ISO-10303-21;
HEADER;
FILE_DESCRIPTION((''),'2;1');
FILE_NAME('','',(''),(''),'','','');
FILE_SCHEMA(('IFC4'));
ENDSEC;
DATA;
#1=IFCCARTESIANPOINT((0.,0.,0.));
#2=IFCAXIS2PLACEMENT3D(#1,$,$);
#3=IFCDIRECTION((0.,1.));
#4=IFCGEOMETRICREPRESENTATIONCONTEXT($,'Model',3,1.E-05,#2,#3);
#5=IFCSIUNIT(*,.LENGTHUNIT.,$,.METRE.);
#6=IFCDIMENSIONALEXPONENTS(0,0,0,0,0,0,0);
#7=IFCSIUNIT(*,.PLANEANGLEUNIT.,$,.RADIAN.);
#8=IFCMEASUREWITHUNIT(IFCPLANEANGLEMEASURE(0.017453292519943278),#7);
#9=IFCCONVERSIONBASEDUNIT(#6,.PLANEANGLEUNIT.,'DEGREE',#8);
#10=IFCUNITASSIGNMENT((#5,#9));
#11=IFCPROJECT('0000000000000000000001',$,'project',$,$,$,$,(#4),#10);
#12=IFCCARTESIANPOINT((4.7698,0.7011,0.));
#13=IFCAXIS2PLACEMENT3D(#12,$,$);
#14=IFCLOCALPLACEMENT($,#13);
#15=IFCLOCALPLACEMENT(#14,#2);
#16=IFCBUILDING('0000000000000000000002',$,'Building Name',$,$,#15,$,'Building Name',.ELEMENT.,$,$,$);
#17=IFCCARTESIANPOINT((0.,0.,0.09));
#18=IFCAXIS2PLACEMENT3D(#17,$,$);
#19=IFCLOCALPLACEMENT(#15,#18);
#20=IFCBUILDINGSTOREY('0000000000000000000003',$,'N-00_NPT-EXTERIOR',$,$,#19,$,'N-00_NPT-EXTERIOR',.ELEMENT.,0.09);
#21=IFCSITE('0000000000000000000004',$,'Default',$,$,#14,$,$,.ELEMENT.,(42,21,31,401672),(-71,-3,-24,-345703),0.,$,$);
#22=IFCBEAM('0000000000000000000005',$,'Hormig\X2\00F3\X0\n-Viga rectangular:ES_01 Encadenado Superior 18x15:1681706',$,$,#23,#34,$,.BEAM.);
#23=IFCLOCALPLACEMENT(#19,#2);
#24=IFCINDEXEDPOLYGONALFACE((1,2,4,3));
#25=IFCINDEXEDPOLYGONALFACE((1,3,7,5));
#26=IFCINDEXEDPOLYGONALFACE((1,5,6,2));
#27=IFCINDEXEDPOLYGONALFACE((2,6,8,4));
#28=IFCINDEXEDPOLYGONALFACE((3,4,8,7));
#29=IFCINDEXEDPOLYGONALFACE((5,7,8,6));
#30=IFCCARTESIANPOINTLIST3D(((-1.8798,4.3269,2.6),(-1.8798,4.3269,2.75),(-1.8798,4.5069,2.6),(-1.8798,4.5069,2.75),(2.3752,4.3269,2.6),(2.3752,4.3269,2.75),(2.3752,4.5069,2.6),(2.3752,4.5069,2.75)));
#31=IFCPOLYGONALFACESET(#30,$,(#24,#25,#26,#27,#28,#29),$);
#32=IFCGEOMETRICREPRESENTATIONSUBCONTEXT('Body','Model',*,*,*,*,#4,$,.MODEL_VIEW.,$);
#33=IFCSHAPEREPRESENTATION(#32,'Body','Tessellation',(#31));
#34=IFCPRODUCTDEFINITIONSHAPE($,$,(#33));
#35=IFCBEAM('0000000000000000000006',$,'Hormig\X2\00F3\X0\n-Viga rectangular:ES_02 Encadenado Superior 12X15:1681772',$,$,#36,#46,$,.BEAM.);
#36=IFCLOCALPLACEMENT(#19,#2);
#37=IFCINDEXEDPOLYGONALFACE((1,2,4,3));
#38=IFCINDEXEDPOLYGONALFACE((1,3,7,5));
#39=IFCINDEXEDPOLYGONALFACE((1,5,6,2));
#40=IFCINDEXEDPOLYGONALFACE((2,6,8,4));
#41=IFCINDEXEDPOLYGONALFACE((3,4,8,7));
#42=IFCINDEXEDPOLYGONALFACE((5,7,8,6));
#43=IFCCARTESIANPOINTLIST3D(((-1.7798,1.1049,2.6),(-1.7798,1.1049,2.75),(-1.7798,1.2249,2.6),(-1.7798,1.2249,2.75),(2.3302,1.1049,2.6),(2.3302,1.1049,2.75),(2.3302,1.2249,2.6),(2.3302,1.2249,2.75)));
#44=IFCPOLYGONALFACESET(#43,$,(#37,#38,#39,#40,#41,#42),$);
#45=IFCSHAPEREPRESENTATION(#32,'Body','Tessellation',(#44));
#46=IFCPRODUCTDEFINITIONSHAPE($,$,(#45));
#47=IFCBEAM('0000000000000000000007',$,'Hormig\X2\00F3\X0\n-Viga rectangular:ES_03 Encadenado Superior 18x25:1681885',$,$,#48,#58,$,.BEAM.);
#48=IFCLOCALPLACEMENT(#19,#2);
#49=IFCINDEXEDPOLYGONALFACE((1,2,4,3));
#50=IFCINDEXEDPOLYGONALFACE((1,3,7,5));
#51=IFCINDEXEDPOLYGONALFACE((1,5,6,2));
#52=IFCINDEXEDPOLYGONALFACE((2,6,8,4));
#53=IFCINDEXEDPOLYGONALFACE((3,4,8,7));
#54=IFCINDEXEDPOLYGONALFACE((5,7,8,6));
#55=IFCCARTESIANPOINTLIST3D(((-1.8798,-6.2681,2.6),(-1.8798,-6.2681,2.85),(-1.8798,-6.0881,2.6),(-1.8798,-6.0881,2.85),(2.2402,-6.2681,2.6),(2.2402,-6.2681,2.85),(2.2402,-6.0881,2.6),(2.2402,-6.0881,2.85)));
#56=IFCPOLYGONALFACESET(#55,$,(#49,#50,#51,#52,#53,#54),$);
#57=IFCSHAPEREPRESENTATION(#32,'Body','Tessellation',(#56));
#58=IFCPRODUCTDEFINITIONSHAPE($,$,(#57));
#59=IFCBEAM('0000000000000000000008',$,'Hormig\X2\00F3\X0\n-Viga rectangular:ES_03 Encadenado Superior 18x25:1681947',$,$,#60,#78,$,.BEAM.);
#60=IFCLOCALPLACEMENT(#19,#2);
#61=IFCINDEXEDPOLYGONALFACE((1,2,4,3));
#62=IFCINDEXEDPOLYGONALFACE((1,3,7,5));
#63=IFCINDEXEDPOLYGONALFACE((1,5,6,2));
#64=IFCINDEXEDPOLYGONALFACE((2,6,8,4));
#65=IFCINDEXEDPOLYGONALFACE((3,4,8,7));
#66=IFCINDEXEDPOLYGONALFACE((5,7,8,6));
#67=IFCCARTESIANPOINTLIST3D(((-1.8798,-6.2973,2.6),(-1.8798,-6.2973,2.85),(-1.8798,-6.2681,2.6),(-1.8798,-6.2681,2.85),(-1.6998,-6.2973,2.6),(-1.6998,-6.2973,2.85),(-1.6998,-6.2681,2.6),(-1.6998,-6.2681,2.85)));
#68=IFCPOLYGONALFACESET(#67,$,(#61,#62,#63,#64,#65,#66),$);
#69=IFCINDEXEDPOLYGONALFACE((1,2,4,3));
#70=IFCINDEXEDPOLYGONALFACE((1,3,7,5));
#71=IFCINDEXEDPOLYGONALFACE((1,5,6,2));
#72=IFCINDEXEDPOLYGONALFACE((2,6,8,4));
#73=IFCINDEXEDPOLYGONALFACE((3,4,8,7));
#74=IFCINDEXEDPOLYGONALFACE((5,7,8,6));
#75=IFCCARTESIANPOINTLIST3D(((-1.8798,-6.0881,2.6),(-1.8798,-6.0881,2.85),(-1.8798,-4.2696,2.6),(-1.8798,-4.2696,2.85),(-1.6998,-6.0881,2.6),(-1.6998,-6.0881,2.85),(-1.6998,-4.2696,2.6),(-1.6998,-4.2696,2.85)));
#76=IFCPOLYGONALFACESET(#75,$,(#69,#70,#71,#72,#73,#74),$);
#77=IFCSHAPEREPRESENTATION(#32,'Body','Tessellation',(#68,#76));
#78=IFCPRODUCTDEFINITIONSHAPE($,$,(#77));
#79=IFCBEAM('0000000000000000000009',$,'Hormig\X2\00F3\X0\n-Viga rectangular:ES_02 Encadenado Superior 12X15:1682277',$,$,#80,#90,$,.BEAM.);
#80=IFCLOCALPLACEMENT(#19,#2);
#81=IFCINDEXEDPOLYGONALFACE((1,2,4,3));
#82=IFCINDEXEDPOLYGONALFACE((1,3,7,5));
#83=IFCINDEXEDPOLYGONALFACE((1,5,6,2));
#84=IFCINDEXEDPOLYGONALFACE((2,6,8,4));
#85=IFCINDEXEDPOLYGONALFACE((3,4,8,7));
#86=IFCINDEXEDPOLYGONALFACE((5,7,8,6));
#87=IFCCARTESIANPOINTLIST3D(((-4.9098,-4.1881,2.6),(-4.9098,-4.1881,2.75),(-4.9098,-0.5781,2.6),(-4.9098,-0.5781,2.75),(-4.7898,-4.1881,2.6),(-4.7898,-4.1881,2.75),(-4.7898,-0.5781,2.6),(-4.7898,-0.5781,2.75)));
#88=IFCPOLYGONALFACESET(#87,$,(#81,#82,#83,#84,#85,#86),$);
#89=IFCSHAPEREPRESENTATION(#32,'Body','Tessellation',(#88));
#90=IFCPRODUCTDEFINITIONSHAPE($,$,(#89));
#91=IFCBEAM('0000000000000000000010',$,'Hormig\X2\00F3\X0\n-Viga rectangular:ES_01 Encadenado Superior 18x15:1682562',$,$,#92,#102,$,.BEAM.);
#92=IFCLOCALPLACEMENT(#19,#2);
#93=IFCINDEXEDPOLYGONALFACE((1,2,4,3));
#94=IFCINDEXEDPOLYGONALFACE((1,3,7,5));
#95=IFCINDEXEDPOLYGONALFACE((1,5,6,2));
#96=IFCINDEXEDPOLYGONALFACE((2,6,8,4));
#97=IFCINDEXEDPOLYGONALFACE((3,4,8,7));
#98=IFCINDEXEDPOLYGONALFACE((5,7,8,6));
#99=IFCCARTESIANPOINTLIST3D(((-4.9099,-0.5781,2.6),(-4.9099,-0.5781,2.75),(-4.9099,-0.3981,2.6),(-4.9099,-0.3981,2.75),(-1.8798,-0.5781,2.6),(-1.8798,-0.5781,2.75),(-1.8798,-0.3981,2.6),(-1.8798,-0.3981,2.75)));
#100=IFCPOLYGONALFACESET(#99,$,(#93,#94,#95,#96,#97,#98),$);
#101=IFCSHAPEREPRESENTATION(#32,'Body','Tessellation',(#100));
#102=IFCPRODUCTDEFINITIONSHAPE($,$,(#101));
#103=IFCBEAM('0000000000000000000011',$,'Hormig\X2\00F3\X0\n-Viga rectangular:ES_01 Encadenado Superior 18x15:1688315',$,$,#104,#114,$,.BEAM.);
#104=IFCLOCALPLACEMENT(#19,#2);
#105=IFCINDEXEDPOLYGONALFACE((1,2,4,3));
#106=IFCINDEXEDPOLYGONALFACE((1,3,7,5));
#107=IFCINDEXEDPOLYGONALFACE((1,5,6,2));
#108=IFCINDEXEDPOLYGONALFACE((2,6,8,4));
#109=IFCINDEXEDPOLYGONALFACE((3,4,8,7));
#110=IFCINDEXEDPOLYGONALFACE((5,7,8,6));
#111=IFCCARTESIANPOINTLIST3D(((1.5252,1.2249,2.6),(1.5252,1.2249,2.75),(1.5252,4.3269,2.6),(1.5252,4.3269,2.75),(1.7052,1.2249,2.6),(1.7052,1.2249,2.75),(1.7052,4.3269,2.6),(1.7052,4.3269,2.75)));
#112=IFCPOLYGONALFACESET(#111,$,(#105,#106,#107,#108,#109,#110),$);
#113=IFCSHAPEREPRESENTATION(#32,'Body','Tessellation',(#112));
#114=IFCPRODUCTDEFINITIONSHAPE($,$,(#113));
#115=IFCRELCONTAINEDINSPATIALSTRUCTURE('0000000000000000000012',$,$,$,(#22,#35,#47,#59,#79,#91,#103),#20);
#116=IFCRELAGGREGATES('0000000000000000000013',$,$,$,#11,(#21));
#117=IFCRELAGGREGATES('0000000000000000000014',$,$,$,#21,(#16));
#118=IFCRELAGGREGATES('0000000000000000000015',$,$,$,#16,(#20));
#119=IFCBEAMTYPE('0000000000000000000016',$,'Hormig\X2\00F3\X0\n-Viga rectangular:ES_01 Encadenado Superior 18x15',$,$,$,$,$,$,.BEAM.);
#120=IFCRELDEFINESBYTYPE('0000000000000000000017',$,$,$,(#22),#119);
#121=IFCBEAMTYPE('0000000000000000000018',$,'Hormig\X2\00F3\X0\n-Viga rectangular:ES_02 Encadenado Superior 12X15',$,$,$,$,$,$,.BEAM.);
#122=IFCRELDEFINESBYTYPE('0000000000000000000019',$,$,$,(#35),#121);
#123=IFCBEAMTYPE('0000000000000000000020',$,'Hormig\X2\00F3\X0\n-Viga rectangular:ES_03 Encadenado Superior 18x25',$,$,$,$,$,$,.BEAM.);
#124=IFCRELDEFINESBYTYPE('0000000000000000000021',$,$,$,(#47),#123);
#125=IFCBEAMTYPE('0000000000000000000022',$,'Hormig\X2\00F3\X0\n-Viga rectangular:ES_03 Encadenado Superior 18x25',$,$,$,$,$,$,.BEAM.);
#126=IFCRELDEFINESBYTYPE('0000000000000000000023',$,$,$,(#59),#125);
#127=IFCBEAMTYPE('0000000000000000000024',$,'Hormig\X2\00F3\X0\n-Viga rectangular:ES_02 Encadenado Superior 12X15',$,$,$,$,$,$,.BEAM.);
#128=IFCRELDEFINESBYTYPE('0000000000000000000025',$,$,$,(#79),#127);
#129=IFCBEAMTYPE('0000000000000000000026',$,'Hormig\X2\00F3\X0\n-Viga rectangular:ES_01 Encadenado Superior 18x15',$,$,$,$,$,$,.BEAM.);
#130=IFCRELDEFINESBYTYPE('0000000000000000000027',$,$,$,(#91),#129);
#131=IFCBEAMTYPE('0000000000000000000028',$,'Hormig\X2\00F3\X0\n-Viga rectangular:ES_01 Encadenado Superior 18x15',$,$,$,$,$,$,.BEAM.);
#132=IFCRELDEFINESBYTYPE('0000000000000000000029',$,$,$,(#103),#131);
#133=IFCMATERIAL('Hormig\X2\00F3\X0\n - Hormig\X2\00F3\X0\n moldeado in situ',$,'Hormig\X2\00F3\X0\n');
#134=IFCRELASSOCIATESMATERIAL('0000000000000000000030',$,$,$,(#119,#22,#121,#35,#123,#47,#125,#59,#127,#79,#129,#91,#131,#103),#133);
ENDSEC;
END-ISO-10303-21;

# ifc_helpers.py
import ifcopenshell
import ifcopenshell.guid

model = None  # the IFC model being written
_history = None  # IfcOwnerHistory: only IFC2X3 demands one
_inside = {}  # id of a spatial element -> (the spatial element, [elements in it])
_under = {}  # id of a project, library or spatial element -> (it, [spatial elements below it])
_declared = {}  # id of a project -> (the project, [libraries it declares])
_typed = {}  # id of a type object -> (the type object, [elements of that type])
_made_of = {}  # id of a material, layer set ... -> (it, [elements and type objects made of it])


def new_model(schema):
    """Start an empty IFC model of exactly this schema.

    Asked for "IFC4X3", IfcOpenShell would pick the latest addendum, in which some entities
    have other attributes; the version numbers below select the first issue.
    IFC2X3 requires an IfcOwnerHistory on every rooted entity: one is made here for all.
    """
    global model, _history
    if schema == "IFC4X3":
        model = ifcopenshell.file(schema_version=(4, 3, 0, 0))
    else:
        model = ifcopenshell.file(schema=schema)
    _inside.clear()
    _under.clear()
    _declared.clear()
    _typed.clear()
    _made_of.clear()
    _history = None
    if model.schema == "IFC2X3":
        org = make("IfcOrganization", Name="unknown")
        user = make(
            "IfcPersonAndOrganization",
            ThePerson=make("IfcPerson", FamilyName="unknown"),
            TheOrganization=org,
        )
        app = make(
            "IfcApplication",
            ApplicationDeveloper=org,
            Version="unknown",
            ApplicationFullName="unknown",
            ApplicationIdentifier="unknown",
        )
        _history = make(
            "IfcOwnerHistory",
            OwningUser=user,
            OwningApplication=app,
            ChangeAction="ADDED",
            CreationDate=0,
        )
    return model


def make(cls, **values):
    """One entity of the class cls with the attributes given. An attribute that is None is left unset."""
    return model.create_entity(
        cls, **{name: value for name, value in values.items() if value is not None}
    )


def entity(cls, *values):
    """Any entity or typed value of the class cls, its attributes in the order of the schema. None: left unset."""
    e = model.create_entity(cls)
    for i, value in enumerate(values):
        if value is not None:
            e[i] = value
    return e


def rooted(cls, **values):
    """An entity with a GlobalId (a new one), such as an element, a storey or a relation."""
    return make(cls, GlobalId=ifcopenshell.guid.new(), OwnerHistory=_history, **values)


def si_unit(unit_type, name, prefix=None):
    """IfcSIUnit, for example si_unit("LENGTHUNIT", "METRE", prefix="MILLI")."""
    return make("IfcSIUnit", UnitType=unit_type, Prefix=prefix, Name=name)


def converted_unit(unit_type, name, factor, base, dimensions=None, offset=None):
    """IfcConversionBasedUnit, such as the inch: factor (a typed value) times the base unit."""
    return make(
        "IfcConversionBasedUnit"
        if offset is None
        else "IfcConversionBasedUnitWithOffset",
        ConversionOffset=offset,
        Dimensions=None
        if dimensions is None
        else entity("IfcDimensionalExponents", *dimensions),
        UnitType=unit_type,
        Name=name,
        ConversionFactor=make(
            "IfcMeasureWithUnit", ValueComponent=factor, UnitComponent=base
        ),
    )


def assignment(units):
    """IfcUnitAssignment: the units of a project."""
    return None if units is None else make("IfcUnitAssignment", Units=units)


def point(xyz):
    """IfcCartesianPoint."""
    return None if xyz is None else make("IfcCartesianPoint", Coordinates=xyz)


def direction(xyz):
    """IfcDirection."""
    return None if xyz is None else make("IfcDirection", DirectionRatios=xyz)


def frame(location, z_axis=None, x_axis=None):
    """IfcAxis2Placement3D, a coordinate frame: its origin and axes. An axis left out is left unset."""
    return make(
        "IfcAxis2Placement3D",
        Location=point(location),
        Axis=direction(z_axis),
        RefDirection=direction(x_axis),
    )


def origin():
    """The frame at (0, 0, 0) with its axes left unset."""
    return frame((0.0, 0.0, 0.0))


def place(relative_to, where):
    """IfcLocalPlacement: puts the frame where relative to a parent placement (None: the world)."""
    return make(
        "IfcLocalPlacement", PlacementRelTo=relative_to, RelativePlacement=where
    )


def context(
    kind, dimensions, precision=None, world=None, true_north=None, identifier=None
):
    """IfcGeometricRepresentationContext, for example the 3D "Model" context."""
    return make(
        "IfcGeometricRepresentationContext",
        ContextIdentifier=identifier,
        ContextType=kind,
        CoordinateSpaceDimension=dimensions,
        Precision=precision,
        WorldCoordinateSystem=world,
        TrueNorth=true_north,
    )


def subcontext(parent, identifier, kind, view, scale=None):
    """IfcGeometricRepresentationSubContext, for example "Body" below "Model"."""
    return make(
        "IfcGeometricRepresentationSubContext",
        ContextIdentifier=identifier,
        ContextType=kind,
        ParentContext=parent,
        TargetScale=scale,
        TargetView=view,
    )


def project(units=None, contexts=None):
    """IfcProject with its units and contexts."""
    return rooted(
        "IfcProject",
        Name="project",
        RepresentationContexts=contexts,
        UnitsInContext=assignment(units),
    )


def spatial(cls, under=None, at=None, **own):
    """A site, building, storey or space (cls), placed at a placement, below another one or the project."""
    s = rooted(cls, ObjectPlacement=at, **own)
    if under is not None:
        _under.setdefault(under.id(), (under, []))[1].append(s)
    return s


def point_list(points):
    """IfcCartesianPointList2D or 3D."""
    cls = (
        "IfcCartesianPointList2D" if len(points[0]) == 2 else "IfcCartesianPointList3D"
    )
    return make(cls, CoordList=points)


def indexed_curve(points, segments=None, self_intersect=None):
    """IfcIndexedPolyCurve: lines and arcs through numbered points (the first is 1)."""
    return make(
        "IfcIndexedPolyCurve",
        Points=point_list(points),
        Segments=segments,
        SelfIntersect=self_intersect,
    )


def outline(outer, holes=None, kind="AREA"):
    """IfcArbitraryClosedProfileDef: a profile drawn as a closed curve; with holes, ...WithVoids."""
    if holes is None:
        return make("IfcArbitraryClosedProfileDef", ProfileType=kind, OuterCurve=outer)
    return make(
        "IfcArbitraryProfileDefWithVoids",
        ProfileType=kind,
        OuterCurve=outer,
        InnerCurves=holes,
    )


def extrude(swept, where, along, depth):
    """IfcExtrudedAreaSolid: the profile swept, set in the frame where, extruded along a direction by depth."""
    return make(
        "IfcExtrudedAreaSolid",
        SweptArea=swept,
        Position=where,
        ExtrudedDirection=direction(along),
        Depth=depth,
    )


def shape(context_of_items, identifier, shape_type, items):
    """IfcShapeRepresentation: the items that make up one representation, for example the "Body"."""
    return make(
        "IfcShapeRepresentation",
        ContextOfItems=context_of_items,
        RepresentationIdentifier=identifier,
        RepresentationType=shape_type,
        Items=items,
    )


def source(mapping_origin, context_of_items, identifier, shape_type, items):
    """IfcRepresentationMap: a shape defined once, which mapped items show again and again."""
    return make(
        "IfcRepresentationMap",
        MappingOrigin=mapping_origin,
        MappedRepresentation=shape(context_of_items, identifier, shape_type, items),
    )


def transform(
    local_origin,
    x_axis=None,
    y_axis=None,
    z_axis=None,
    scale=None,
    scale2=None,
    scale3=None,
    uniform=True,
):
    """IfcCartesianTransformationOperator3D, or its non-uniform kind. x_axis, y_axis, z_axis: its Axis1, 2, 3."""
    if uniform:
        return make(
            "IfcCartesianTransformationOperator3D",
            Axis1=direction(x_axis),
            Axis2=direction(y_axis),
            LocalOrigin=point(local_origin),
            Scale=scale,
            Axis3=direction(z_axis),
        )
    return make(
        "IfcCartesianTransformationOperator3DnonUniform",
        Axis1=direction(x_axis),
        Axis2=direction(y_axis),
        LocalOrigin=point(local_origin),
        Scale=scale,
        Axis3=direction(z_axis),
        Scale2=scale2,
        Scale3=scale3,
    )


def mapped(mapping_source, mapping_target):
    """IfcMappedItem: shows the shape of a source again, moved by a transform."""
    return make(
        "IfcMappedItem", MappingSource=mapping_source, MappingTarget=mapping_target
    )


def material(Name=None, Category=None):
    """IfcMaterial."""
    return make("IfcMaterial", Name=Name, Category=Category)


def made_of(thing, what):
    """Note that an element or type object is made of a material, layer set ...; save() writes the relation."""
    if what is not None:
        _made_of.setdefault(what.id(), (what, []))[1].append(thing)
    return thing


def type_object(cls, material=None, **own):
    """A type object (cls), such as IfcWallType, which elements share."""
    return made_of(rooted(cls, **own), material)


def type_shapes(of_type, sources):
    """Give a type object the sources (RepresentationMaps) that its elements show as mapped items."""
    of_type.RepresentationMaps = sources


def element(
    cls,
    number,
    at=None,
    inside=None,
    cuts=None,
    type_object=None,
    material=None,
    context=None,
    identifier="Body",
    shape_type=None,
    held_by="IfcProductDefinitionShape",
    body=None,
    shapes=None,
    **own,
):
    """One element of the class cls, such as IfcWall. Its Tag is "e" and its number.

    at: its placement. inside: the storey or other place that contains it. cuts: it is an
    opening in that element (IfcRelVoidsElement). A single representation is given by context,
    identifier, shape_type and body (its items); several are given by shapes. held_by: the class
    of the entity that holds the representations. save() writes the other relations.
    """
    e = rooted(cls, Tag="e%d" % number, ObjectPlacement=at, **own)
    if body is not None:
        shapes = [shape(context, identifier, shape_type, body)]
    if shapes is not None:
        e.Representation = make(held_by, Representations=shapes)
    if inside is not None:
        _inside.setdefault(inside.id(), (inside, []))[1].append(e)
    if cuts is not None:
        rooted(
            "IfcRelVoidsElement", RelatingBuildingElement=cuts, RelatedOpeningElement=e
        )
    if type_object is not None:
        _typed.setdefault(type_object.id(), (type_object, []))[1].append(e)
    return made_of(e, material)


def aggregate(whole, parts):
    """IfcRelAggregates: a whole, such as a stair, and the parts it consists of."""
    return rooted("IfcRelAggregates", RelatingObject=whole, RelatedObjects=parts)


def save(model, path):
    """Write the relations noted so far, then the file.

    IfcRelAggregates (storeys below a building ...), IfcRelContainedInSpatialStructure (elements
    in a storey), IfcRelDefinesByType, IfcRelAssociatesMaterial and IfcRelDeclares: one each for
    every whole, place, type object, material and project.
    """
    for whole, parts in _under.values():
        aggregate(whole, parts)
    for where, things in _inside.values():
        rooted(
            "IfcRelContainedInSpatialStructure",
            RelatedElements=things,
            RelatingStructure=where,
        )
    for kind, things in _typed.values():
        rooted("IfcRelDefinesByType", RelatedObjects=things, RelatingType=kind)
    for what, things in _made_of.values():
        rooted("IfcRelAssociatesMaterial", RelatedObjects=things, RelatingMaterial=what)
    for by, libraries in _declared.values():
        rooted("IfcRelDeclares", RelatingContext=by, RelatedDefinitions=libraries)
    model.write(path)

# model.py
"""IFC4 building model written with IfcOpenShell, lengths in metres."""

from ifc_helpers import new_model, entity, si_unit, converted_unit, direction, frame, origin, place, context, subcontext, project, spatial, indexed_curve, outline, extrude, source, transform, mapped, material, type_object, type_shapes, element, save


model = new_model("IFC4")

# Units and contexts
model_context = context("Model", 3, precision=1e-05, world=origin(), true_north=direction((0.0, 1.0)))
body_context = subcontext(model_context, "Body", "Model", "MODEL_VIEW")
ifc_project = project(units=[si_unit("LENGTHUNIT", "METRE"), converted_unit("PLANEANGLEUNIT", "DEGREE", entity("IfcPlaneAngleMeasure", 0.017453292519943278), si_unit("PLANEANGLEUNIT", "RADIAN"), dimensions=[0, 0, 0, 0, 0, 0, 0])], contexts=[model_context])

# Site, building, storey
site_placement = place(None, frame((4.7698, 0.7011, 0.0)))
site = spatial("IfcSite", under=ifc_project, at=site_placement, Name="Default", CompositionType="ELEMENT", RefLatitude=(42, 21, 31, 401672), RefLongitude=(-71, -3, -24, -345703), RefElevation=0.0)
building_placement = place(site_placement, origin())
building = spatial("IfcBuilding", under=site, at=building_placement, Name="Building Name", LongName="Building Name", CompositionType="ELEMENT")
storey_placement = place(building_placement, frame((0.0, 0.0, 0.09)))
storey = spatial("IfcBuildingStorey", under=building, at=storey_placement, Name="N-00_NPT-EXTERIOR", LongName="N-00_NPT-EXTERIOR", CompositionType="ELEMENT", Elevation=0.09)

# Beams
ifc_material_1 = material(Name="Hormigón - Hormigón moldeado in situ", Category="Hormigón")
beam_type_1 = type_object("IfcBeamType", Name="Hormigón-Viga rectangular:ES_01 Encadenado Superior 18x15", PredefinedType="BEAM", material=ifc_material_1)
shared_shape_1 = source(origin(), body_context, "Body", "SweptSolid", [
    extrude(outline(indexed_curve([(-0.075, -0.09), (0.075, -0.09), (0.075, 0.09), (-0.075, 0.09), (-0.075, -0.09)], self_intersect=False)), frame((2.3752, 4.4169, 2.765), z_axis=(-1.0, 0.0, 0.0), x_axis=(0.0, 0.0, -1.0)), (0.0, 0.0, 1.0), 4.255),
])
type_shapes(beam_type_1, [shared_shape_1])
beam_1_placement = place(storey_placement, frame((0.0, 0.0, -0.09)))
element("IfcBeam", 1, at=beam_1_placement, inside=storey, type_object=beam_type_1, material=ifc_material_1, Name="Hormigón-Viga rectangular:ES_01 Encadenado Superior 18x15:1681706", PredefinedType="BEAM", context=body_context, shape_type="MappedRepresentation", body=[
    mapped(shared_shape_1, transform((0.0, 0.0, 0.0), scale=1.0)),
])
beam_type_2 = type_object("IfcBeamType", Name="Hormigón-Viga rectangular:ES_02 Encadenado Superior 12X15", PredefinedType="BEAM", material=ifc_material_1)
shared_shape_2 = source(origin(), body_context, "Body", "SweptSolid", [
    extrude(outline(indexed_curve([(-0.075, -0.06), (0.075, -0.06), (0.075, 0.06), (-0.075, 0.06), (-0.075, -0.06)], self_intersect=False)), frame((2.3302, 1.1649, 2.765), z_axis=(-1.0, 0.0, 0.0), x_axis=(0.0, 0.0, -1.0)), (0.0, 0.0, 1.0), 4.11),
])
type_shapes(beam_type_2, [shared_shape_2])
beam_2_placement = place(storey_placement, frame((0.0, 0.0, -0.09)))
element("IfcBeam", 2, at=beam_2_placement, inside=storey, type_object=beam_type_2, material=ifc_material_1, Name="Hormigón-Viga rectangular:ES_02 Encadenado Superior 12X15:1681772", PredefinedType="BEAM", context=body_context, shape_type="MappedRepresentation", body=[
    mapped(shared_shape_2, transform((0.0, 0.0, 0.0), scale=1.0)),
])
beam_type_3 = type_object("IfcBeamType", Name="Hormigón-Viga rectangular:ES_03 Encadenado Superior 18x25", PredefinedType="BEAM", material=ifc_material_1)
shared_shape_3 = source(origin(), body_context, "Body", "SweptSolid", [
    extrude(outline(indexed_curve([(-0.125, -0.09), (0.125, -0.09), (0.125, 0.09), (-0.125, 0.09), (-0.125, -0.09)], self_intersect=False)), frame((2.2402, -6.1781, 2.815), z_axis=(-1.0, 0.0, 0.0), x_axis=(0.0, 0.0, -1.0)), (0.0, 0.0, 1.0), 4.12),
])
type_shapes(beam_type_3, [shared_shape_3])
beam_3_placement = place(storey_placement, frame((0.0, 0.0, -0.09)))
element("IfcBeam", 3, at=beam_3_placement, inside=storey, type_object=beam_type_3, material=ifc_material_1, Name="Hormigón-Viga rectangular:ES_03 Encadenado Superior 18x25:1681885", PredefinedType="BEAM", context=body_context, shape_type="MappedRepresentation", body=[
    mapped(shared_shape_3, transform((0.0, 0.0, 0.0), scale=1.0)),
])
beam_type_4 = type_object("IfcBeamType", Name="Hormigón-Viga rectangular:ES_03 Encadenado Superior 18x25", PredefinedType="BEAM", material=ifc_material_1)
shared_shape_4 = source(origin(), body_context, "Body", "SweptSolid", [
    extrude(outline(indexed_curve([(-0.09, -0.125), (0.09, -0.125), (0.09, 0.125), (-0.09, 0.125), (-0.09, -0.125)], self_intersect=False)), frame((-1.7898, -6.2973, 2.815), z_axis=(0.0, 1.0, 0.0), x_axis=(-1.0, 0.0, 0.0)), (0.0, 0.0, 1.0), 0.0291),
    extrude(outline(indexed_curve([(-0.09, -0.125), (0.09, -0.125), (0.09, 0.125), (-0.09, 0.125), (-0.09, -0.125)], self_intersect=False)), frame((-1.7898, -6.0881, 2.815), z_axis=(0.0, 1.0, 0.0), x_axis=(-1.0, 0.0, 0.0)), (0.0, 0.0, 1.0), 1.8186),
])
type_shapes(beam_type_4, [shared_shape_4])
beam_4_placement = place(storey_placement, frame((0.0, 0.0, -0.09)))
element("IfcBeam", 4, at=beam_4_placement, inside=storey, type_object=beam_type_4, material=ifc_material_1, Name="Hormigón-Viga rectangular:ES_03 Encadenado Superior 18x25:1681947", PredefinedType="BEAM", context=body_context, shape_type="MappedRepresentation", body=[
    mapped(shared_shape_4, transform((0.0, 0.0, 0.0), scale=1.0)),
])
beam_type_5 = type_object("IfcBeamType", Name="Hormigón-Viga rectangular:ES_02 Encadenado Superior 12X15", PredefinedType="BEAM", material=ifc_material_1)
shared_shape_5 = source(origin(), body_context, "Body", "SweptSolid", [
    extrude(outline(indexed_curve([(-0.06, -0.075), (0.06, -0.075), (0.06, 0.075), (-0.06, 0.075), (-0.06, -0.075)], self_intersect=False)), frame((-4.8498, -4.1881, 2.765), z_axis=(0.0, 1.0, 0.0), x_axis=(-1.0, 0.0, 0.0)), (0.0, 0.0, 1.0), 3.61),
])
type_shapes(beam_type_5, [shared_shape_5])
beam_5_placement = place(storey_placement, frame((0.0, 0.0, -0.09)))
element("IfcBeam", 5, at=beam_5_placement, inside=storey, type_object=beam_type_5, material=ifc_material_1, Name="Hormigón-Viga rectangular:ES_02 Encadenado Superior 12X15:1682277", PredefinedType="BEAM", context=body_context, shape_type="MappedRepresentation", body=[
    mapped(shared_shape_5, transform((0.0, 0.0, 0.0), scale=1.0)),
])
beam_type_6 = type_object("IfcBeamType", Name="Hormigón-Viga rectangular:ES_01 Encadenado Superior 18x15", PredefinedType="BEAM", material=ifc_material_1)
shared_shape_6 = source(origin(), body_context, "Body", "SweptSolid", [
    extrude(outline(indexed_curve([(-0.075, -0.09), (0.075, -0.09), (0.075, 0.09), (-0.075, 0.09), (-0.075, -0.09)], self_intersect=False)), frame((-4.9099, -0.4881, 2.765), z_axis=(1.0, 0.0, 0.0), x_axis=(0.0, 0.0, -1.0)), (0.0, 0.0, 1.0), 3.0302),
])
type_shapes(beam_type_6, [shared_shape_6])
beam_6_placement = place(storey_placement, frame((0.0, 0.0, -0.09)))
element("IfcBeam", 6, at=beam_6_placement, inside=storey, type_object=beam_type_6, material=ifc_material_1, Name="Hormigón-Viga rectangular:ES_01 Encadenado Superior 18x15:1682562", PredefinedType="BEAM", context=body_context, shape_type="MappedRepresentation", body=[
    mapped(shared_shape_6, transform((0.0, 0.0, 0.0), scale=1.0)),
])
beam_type_7 = type_object("IfcBeamType", Name="Hormigón-Viga rectangular:ES_01 Encadenado Superior 18x15", PredefinedType="BEAM", material=ifc_material_1)
shared_shape_7 = source(origin(), body_context, "Body", "SweptSolid", [
    extrude(outline(indexed_curve([(-0.09, -0.075), (0.09, -0.075), (0.09, 0.075), (-0.09, 0.075), (-0.09, -0.075)], self_intersect=False)), frame((1.6152, 1.2249, 2.765), z_axis=(0.0, 1.0, 0.0), x_axis=(-1.0, 0.0, 0.0)), (0.0, 0.0, 1.0), 3.102),
])
type_shapes(beam_type_7, [shared_shape_7])
beam_7_placement = place(storey_placement, frame((0.0, 0.0, -0.09)))
element("IfcBeam", 7, at=beam_7_placement, inside=storey, type_object=beam_type_7, material=ifc_material_1, Name="Hormigón-Viga rectangular:ES_01 Encadenado Superior 18x15:1688315", PredefinedType="BEAM", context=body_context, shape_type="MappedRepresentation", body=[
    mapped(shared_shape_7, transform((0.0, 0.0, 0.0), scale=1.0)),
])

save(model, "model.ifc")
